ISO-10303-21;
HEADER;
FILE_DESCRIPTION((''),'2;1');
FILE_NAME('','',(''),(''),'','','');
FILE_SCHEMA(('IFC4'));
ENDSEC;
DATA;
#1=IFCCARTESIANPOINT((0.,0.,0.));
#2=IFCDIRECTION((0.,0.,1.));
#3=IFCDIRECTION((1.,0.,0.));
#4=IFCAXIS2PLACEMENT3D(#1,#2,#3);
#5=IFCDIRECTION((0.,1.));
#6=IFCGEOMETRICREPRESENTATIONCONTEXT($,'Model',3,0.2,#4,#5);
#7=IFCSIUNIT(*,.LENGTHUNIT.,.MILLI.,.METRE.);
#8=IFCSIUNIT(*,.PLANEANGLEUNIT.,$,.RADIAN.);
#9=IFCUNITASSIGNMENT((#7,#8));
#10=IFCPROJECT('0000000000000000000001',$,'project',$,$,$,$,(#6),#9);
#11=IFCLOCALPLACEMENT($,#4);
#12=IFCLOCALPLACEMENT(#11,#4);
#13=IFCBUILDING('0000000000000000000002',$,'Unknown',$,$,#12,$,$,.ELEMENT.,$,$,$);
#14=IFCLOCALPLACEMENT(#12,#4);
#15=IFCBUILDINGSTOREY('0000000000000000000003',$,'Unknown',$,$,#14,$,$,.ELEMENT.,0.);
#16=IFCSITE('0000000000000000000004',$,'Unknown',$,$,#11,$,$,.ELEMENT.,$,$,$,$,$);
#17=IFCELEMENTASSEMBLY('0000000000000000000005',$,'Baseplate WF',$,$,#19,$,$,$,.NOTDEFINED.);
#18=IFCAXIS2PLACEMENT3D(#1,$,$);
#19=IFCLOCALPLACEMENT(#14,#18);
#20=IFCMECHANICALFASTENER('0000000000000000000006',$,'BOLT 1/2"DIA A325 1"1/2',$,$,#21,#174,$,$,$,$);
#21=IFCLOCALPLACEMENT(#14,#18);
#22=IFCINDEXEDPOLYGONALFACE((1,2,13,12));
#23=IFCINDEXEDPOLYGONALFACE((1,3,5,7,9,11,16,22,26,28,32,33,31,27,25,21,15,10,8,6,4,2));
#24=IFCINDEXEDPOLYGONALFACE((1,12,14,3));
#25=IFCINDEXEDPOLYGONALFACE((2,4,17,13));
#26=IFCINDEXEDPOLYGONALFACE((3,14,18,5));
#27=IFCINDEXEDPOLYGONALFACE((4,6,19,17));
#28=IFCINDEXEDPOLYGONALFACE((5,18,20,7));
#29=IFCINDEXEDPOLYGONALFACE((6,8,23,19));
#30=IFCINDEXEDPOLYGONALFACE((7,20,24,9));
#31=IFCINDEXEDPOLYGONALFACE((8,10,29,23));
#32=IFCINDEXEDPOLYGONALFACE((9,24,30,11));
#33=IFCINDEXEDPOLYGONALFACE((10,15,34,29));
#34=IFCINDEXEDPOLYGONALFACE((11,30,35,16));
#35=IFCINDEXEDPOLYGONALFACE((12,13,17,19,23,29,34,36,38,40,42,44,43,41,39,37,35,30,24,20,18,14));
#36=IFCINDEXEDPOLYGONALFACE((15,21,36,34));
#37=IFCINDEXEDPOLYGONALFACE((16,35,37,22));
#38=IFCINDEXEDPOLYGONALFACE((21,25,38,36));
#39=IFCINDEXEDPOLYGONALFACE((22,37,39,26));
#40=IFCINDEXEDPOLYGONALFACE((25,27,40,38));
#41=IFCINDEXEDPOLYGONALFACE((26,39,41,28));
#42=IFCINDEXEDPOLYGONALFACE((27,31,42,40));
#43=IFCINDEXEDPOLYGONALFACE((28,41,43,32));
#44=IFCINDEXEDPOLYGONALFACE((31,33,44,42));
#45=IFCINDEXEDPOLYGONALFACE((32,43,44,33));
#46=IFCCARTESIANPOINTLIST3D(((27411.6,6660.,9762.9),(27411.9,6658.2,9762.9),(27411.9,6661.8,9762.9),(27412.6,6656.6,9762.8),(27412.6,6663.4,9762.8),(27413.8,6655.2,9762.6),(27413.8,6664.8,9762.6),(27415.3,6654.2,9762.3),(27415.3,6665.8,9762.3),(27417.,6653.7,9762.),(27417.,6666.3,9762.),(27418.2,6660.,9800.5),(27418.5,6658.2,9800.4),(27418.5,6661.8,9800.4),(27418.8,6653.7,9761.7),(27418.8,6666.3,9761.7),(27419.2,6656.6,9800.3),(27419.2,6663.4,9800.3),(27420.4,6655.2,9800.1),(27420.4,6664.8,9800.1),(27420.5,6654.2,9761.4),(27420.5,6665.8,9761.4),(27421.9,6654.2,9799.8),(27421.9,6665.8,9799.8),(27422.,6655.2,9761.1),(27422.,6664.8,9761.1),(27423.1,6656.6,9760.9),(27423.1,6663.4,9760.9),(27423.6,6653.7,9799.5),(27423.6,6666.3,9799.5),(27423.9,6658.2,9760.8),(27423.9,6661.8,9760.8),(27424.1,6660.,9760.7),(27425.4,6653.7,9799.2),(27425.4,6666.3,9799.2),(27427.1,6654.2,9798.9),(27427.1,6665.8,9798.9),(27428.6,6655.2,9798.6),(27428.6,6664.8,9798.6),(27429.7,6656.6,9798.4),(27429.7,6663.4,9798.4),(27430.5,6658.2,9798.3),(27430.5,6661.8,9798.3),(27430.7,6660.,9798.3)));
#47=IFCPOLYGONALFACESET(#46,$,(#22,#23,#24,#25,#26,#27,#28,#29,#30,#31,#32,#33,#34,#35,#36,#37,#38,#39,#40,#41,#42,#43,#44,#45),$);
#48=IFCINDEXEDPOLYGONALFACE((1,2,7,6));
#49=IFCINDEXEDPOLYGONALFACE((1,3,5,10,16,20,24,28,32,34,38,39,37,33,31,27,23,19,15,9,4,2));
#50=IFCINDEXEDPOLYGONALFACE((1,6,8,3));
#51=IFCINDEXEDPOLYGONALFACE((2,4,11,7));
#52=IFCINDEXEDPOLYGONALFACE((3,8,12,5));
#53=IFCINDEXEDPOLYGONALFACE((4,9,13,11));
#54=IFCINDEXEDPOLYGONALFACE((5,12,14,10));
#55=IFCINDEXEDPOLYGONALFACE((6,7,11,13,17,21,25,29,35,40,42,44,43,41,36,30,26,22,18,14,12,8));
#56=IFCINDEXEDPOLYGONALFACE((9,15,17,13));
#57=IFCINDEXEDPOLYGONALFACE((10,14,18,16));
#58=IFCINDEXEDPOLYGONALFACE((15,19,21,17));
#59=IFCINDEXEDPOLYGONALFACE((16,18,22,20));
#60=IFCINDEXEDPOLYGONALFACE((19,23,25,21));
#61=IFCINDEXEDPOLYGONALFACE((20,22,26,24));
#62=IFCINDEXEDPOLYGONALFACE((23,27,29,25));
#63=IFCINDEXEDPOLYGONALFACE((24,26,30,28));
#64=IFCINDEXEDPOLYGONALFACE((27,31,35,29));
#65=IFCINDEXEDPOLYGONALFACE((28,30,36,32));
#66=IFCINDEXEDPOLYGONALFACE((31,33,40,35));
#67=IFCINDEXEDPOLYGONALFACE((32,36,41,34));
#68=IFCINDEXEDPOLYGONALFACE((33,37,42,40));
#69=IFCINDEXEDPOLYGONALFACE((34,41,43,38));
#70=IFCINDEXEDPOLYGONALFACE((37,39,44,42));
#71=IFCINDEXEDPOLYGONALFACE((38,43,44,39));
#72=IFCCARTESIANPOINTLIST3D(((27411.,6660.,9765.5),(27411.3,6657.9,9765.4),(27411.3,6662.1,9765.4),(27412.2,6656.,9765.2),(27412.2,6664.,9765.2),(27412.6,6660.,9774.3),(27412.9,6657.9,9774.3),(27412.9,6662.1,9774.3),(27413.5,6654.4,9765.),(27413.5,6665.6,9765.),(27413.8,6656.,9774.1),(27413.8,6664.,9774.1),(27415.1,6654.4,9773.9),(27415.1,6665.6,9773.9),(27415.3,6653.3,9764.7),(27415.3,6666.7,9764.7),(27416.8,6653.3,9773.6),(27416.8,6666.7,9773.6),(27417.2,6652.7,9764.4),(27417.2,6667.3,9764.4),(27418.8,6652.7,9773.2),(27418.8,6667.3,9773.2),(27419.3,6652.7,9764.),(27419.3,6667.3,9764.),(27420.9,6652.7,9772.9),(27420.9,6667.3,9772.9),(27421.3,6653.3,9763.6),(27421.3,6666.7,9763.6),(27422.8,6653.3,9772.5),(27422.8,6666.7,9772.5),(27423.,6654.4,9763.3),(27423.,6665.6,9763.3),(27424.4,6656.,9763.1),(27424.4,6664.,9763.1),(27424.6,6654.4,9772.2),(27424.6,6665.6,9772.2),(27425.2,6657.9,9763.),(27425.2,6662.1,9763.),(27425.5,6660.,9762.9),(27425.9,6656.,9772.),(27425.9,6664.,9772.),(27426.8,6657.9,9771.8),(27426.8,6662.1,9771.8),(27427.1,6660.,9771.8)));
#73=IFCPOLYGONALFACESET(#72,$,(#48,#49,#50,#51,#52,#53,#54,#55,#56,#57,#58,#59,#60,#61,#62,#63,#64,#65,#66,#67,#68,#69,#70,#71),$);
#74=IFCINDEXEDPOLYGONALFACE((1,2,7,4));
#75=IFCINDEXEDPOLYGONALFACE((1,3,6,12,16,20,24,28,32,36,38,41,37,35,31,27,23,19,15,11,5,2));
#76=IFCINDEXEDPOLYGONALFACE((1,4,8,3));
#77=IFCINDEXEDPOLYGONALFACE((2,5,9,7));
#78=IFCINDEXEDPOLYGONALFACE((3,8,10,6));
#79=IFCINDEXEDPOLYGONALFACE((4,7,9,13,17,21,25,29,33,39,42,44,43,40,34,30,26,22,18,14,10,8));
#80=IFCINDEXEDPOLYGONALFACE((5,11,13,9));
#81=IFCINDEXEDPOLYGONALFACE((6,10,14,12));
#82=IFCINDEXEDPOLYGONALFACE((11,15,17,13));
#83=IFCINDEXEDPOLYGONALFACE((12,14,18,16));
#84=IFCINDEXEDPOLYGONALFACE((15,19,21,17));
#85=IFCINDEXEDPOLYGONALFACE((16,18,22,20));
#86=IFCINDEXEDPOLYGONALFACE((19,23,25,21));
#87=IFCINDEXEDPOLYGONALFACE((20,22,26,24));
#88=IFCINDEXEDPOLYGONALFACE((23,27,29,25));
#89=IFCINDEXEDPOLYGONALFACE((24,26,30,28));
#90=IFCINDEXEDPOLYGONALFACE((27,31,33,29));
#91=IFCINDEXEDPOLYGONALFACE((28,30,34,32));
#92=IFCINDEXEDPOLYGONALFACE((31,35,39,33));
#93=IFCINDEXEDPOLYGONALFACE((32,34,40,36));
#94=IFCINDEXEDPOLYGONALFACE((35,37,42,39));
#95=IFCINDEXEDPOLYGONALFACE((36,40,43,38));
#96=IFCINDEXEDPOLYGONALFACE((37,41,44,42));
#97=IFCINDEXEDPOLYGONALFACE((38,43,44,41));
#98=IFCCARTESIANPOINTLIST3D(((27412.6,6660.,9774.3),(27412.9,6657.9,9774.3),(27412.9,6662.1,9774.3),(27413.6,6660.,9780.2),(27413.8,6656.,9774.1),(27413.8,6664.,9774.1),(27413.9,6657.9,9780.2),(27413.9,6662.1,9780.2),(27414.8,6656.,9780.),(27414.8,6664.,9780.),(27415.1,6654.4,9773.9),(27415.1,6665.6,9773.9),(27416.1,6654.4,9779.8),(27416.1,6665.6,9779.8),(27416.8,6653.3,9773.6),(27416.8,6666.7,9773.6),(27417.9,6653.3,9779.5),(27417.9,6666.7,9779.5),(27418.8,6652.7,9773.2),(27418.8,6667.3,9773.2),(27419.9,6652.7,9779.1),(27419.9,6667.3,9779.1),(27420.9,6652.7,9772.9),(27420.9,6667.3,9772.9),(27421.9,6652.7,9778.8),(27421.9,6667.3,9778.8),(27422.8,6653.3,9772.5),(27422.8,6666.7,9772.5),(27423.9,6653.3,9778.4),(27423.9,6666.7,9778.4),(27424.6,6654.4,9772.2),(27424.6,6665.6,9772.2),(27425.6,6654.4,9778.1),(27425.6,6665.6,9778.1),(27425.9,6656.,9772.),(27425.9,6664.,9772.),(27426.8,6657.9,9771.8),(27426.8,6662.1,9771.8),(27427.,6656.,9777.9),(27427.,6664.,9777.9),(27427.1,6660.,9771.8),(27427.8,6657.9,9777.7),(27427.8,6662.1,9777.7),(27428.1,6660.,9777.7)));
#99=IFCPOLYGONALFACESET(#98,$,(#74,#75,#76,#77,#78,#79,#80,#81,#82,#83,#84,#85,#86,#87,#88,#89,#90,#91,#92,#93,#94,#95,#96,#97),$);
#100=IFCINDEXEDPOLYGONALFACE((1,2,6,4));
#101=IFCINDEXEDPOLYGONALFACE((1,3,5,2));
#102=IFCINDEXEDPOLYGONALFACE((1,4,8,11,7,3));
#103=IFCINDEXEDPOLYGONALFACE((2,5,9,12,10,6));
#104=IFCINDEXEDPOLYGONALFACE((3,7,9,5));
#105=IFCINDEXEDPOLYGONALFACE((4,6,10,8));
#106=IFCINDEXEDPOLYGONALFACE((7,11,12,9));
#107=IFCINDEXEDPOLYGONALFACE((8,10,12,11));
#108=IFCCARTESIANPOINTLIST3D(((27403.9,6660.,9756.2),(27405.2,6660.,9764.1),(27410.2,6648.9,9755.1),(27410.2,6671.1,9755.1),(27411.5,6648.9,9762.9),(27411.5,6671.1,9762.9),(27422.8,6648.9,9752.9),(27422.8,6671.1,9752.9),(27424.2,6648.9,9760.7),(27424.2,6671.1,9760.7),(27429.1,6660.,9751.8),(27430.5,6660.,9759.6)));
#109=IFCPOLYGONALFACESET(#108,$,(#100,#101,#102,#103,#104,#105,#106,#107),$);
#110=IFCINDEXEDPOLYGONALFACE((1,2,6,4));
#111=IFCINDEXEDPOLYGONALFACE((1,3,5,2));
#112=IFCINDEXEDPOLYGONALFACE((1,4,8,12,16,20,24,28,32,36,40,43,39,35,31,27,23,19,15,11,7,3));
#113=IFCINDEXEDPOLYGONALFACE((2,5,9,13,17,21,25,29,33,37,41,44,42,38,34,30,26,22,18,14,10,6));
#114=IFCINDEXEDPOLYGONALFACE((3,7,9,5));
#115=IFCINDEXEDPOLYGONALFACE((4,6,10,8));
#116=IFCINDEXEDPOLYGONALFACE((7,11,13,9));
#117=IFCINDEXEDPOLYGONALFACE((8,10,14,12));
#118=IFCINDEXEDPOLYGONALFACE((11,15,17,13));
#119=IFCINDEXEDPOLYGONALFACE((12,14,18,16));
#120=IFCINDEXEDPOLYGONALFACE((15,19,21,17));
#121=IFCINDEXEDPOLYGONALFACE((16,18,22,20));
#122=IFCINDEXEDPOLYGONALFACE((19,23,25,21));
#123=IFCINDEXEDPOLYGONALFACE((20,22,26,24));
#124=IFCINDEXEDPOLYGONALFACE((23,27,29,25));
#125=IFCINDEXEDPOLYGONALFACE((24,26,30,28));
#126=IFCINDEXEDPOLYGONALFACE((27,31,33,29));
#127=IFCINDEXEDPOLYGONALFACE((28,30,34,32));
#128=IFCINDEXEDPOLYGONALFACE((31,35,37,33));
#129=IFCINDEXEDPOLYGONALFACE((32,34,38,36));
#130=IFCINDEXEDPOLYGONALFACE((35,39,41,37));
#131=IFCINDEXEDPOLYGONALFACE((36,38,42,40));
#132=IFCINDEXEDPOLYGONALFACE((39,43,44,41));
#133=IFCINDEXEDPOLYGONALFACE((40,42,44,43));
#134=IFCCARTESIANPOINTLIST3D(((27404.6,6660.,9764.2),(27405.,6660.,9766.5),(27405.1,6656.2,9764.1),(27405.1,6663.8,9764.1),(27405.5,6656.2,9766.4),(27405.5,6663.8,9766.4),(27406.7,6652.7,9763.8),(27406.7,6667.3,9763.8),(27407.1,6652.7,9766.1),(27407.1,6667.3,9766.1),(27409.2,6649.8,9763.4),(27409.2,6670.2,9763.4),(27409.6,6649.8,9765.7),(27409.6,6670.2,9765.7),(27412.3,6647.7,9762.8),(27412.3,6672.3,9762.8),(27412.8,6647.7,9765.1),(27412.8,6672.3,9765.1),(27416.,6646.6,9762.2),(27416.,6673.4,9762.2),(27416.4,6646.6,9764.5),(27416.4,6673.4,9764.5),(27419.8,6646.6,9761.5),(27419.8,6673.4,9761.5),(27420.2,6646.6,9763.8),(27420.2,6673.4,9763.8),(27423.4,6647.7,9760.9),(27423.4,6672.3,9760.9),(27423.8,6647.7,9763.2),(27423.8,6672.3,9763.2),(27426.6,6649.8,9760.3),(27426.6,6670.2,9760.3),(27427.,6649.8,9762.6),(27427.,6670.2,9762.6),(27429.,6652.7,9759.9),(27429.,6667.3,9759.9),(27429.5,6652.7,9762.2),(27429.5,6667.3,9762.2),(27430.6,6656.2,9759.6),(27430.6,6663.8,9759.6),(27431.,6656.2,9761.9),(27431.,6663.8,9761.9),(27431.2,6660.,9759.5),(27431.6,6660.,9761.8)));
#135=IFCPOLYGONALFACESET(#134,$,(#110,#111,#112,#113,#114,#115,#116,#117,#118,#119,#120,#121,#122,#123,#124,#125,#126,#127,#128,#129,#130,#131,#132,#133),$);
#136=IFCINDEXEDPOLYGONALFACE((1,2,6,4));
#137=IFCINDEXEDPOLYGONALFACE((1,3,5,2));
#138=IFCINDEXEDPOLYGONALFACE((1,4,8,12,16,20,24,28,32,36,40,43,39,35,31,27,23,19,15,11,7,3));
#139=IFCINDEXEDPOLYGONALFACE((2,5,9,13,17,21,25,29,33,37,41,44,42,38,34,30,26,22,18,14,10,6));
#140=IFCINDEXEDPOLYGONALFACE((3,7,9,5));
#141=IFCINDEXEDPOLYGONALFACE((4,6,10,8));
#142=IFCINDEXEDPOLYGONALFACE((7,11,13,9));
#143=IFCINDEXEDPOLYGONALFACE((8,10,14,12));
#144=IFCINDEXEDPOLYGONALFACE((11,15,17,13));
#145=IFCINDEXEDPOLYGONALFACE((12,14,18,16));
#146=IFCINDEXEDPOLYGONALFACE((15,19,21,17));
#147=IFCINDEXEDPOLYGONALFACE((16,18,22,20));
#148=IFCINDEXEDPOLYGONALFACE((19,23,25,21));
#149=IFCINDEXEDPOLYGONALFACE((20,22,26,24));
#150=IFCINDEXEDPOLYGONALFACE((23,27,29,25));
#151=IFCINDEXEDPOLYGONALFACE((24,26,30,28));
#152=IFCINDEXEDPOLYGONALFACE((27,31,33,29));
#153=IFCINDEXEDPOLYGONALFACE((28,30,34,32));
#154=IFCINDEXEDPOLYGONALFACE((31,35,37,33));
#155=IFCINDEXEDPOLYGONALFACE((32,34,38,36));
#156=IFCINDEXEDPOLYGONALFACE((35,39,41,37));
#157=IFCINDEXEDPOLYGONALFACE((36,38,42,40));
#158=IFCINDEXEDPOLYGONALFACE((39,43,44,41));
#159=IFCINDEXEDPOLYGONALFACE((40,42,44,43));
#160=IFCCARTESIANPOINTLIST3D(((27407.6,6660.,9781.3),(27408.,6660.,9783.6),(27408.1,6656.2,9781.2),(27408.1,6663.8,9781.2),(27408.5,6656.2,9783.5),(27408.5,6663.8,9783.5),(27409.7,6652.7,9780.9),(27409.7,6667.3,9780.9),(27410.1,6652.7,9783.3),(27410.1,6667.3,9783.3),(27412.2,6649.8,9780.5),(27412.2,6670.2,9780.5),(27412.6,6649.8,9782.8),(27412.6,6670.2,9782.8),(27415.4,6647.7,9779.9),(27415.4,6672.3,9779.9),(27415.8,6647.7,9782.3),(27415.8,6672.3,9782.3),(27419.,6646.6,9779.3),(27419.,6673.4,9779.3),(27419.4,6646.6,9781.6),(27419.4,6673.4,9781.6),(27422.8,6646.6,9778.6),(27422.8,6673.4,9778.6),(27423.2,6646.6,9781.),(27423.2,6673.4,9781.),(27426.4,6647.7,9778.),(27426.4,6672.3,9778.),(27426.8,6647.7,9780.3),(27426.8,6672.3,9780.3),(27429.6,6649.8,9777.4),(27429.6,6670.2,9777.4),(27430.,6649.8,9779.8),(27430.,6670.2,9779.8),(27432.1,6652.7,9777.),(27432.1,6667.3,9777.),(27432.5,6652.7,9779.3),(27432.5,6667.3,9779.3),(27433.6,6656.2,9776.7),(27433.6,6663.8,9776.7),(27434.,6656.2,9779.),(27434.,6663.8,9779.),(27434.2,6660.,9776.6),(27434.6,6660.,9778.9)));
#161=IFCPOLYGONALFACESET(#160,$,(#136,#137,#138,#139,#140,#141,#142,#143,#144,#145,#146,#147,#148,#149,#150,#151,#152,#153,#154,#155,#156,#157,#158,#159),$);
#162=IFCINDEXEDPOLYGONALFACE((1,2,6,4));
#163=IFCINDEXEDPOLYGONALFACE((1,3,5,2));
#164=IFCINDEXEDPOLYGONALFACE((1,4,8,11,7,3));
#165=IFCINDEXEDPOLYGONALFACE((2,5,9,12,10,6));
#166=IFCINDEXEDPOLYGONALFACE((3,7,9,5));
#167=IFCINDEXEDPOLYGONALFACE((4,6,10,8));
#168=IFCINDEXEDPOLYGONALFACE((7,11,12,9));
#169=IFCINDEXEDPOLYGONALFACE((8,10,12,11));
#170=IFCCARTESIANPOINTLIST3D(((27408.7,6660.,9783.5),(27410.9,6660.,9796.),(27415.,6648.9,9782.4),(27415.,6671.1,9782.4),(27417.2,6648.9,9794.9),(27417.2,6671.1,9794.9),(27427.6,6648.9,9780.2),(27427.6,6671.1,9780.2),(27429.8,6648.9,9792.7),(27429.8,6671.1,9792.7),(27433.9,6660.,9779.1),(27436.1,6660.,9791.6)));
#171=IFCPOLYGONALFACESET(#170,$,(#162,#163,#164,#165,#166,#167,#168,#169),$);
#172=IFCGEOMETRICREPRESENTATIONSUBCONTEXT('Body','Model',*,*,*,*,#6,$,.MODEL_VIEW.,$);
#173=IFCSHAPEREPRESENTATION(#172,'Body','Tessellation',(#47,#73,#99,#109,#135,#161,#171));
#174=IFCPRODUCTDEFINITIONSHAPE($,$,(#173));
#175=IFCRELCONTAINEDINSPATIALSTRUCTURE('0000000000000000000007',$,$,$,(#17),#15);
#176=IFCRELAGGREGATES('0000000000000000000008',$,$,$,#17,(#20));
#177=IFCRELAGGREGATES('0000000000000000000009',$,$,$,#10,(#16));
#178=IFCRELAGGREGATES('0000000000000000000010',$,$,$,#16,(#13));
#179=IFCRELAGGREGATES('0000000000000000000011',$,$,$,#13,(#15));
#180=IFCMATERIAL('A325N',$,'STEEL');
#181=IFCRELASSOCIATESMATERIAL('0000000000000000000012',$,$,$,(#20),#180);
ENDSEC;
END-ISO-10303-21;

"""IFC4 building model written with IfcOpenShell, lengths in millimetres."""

from ifc_helpers import new_model, si_unit, direction, frame, origin_with_axes, place, context, subcontext, project, spatial, line, arc, indexed_curve, outline, extrude, source, transform, mapped, material, element, aggregate, save


model = new_model("IFC4")

# Units and contexts
model_context = context("Model", 3, precision=0.2, world=origin_with_axes(), true_north=direction((0.0, 1.0)))
body_context = subcontext(model_context, "Body", "Model", "MODEL_VIEW")
ifc_project = project(units=[si_unit("LENGTHUNIT", "METRE", prefix="MILLI"), si_unit("PLANEANGLEUNIT", "RADIAN")], contexts=[model_context])

# Site, building, storey
site_placement = place(None, origin_with_axes())
site = spatial("IfcSite", under=ifc_project, at=site_placement, Name="Unknown", CompositionType="ELEMENT")
building_placement = place(site_placement, origin_with_axes())
building = spatial("IfcBuilding", under=site, at=building_placement, Name="Unknown", CompositionType="ELEMENT")
storey_placement = place(building_placement, origin_with_axes())
storey = spatial("IfcBuildingStorey", under=building, at=storey_placement, Name="Unknown", CompositionType="ELEMENT", Elevation=0.0)

# Shared definitions
ifc_material_1 = material(Name="A325N", Category="STEEL")
shared_shape_1 = source(origin_with_axes(), body_context, "Body", "SweptSolid", [
    extrude(outline(indexed_curve([(6.3, 0.0), (0.0, 6.3), (-6.3, 0.0), (0.0, -6.3)], segments=[arc(1, 2, 3), arc(3, 4, 1)])), frame((0.0, 0.0, 17.4), z_axis=(0.0, 0.0, -1.0), x_axis=(0.0, 1.0, 0.0)), (0.0, 0.0, 1.0), 38.1),
    extrude(outline(indexed_curve([(7.3, 0.0), (0.0, 7.3), (-7.3, 0.0), (0.0, -7.3)], segments=[arc(1, 2, 3), arc(3, 4, 1)])), frame((0.0, 0.0, 15.0), z_axis=(0.0, 0.0, -1.0), x_axis=(0.0, 1.0, 0.0)), (0.0, 0.0, 1.0), 9.0),
    extrude(outline(indexed_curve([(7.3, 0.0), (0.0, 7.3), (-7.3, 0.0), (0.0, -7.3)], segments=[arc(1, 2, 3), arc(3, 4, 1)])), frame((0.0, 0.0, 6.0), z_axis=(0.0, 0.0, -1.0), x_axis=(0.0, 1.0, 0.0)), (0.0, 0.0, 1.0), 6.0),
    extrude(outline(indexed_curve([(12.8, 0.0), (6.4, 11.1), (-6.4, 11.1), (-12.8, 0.0), (-6.4, -11.1), (6.4, -11.1)], segments=[line(1, 2, 3, 4, 5, 6, 1)])), frame((0.0, 0.0, 25.3), z_axis=(0.0, 0.0, -1.0), x_axis=(0.0, 1.0, 0.0)), (0.0, 0.0, 1.0), 7.9),
    extrude(outline(indexed_curve([(13.5, 0.0), (0.0, 13.5), (-13.5, 0.0), (0.0, -13.5)], segments=[arc(1, 2, 3), arc(3, 4, 1)])), frame((0.0, 0.0, 17.4), z_axis=(0.0, 0.0, -1.0), x_axis=(0.0, 1.0, 0.0)), (0.0, 0.0, 1.0), 2.4),
    extrude(outline(indexed_curve([(13.5, 0.0), (0.0, 13.5), (-13.5, 0.0), (0.0, -13.5)], segments=[arc(1, 2, 3), arc(3, 4, 1)])), frame((0.0, 0.0, 0.0), z_axis=(0.0, 0.0, -1.0), x_axis=(0.0, 1.0, 0.0)), (0.0, 0.0, 1.0), 2.4),
    extrude(outline(indexed_curve([(12.8, 0.0), (6.4, 11.1), (-6.4, 11.1), (-12.8, 0.0), (-6.4, -11.1), (6.4, -11.1)], segments=[line(1, 2, 3, 4, 5, 6, 1)])), frame((0.0, 0.0, -2.4), z_axis=(0.0, 0.0, -1.0), x_axis=(0.0, 1.0, 0.0)), (0.0, 0.0, 1.0), 12.7),
])

# Element assembly, mechanical fastener
assembly_1_placement = place(storey_placement, frame((27449.9, 6690.0, 9770.8), z_axis=(-0.173648, 0.0, -0.984808), x_axis=(0.0, -1.0, 0.0)))
assembly_1 = element("IfcElementAssembly", 1, at=assembly_1_placement, inside=storey, Name="Baseplate WF", PredefinedType="NOTDEFINED")
mechanical_fastener_1_placement = place(assembly_1_placement, frame((30.0, 30.0, -3.0), z_axis=(0.0, 0.0, 1.0), x_axis=(-1.0, 0.0, 0.0)))
mechanical_fastener_1 = element("IfcMechanicalFastener", 2, at=mechanical_fastener_1_placement, material=ifc_material_1, Name="BOLT 1/2\"DIA A325 1\"1/2", context=body_context, shape_type="MappedRepresentation", body=[
    mapped(shared_shape_1, transform((0.0, 0.0, 0.0))),
])
aggregate(assembly_1, [mechanical_fastener_1])

save(model, "model.ifc")
